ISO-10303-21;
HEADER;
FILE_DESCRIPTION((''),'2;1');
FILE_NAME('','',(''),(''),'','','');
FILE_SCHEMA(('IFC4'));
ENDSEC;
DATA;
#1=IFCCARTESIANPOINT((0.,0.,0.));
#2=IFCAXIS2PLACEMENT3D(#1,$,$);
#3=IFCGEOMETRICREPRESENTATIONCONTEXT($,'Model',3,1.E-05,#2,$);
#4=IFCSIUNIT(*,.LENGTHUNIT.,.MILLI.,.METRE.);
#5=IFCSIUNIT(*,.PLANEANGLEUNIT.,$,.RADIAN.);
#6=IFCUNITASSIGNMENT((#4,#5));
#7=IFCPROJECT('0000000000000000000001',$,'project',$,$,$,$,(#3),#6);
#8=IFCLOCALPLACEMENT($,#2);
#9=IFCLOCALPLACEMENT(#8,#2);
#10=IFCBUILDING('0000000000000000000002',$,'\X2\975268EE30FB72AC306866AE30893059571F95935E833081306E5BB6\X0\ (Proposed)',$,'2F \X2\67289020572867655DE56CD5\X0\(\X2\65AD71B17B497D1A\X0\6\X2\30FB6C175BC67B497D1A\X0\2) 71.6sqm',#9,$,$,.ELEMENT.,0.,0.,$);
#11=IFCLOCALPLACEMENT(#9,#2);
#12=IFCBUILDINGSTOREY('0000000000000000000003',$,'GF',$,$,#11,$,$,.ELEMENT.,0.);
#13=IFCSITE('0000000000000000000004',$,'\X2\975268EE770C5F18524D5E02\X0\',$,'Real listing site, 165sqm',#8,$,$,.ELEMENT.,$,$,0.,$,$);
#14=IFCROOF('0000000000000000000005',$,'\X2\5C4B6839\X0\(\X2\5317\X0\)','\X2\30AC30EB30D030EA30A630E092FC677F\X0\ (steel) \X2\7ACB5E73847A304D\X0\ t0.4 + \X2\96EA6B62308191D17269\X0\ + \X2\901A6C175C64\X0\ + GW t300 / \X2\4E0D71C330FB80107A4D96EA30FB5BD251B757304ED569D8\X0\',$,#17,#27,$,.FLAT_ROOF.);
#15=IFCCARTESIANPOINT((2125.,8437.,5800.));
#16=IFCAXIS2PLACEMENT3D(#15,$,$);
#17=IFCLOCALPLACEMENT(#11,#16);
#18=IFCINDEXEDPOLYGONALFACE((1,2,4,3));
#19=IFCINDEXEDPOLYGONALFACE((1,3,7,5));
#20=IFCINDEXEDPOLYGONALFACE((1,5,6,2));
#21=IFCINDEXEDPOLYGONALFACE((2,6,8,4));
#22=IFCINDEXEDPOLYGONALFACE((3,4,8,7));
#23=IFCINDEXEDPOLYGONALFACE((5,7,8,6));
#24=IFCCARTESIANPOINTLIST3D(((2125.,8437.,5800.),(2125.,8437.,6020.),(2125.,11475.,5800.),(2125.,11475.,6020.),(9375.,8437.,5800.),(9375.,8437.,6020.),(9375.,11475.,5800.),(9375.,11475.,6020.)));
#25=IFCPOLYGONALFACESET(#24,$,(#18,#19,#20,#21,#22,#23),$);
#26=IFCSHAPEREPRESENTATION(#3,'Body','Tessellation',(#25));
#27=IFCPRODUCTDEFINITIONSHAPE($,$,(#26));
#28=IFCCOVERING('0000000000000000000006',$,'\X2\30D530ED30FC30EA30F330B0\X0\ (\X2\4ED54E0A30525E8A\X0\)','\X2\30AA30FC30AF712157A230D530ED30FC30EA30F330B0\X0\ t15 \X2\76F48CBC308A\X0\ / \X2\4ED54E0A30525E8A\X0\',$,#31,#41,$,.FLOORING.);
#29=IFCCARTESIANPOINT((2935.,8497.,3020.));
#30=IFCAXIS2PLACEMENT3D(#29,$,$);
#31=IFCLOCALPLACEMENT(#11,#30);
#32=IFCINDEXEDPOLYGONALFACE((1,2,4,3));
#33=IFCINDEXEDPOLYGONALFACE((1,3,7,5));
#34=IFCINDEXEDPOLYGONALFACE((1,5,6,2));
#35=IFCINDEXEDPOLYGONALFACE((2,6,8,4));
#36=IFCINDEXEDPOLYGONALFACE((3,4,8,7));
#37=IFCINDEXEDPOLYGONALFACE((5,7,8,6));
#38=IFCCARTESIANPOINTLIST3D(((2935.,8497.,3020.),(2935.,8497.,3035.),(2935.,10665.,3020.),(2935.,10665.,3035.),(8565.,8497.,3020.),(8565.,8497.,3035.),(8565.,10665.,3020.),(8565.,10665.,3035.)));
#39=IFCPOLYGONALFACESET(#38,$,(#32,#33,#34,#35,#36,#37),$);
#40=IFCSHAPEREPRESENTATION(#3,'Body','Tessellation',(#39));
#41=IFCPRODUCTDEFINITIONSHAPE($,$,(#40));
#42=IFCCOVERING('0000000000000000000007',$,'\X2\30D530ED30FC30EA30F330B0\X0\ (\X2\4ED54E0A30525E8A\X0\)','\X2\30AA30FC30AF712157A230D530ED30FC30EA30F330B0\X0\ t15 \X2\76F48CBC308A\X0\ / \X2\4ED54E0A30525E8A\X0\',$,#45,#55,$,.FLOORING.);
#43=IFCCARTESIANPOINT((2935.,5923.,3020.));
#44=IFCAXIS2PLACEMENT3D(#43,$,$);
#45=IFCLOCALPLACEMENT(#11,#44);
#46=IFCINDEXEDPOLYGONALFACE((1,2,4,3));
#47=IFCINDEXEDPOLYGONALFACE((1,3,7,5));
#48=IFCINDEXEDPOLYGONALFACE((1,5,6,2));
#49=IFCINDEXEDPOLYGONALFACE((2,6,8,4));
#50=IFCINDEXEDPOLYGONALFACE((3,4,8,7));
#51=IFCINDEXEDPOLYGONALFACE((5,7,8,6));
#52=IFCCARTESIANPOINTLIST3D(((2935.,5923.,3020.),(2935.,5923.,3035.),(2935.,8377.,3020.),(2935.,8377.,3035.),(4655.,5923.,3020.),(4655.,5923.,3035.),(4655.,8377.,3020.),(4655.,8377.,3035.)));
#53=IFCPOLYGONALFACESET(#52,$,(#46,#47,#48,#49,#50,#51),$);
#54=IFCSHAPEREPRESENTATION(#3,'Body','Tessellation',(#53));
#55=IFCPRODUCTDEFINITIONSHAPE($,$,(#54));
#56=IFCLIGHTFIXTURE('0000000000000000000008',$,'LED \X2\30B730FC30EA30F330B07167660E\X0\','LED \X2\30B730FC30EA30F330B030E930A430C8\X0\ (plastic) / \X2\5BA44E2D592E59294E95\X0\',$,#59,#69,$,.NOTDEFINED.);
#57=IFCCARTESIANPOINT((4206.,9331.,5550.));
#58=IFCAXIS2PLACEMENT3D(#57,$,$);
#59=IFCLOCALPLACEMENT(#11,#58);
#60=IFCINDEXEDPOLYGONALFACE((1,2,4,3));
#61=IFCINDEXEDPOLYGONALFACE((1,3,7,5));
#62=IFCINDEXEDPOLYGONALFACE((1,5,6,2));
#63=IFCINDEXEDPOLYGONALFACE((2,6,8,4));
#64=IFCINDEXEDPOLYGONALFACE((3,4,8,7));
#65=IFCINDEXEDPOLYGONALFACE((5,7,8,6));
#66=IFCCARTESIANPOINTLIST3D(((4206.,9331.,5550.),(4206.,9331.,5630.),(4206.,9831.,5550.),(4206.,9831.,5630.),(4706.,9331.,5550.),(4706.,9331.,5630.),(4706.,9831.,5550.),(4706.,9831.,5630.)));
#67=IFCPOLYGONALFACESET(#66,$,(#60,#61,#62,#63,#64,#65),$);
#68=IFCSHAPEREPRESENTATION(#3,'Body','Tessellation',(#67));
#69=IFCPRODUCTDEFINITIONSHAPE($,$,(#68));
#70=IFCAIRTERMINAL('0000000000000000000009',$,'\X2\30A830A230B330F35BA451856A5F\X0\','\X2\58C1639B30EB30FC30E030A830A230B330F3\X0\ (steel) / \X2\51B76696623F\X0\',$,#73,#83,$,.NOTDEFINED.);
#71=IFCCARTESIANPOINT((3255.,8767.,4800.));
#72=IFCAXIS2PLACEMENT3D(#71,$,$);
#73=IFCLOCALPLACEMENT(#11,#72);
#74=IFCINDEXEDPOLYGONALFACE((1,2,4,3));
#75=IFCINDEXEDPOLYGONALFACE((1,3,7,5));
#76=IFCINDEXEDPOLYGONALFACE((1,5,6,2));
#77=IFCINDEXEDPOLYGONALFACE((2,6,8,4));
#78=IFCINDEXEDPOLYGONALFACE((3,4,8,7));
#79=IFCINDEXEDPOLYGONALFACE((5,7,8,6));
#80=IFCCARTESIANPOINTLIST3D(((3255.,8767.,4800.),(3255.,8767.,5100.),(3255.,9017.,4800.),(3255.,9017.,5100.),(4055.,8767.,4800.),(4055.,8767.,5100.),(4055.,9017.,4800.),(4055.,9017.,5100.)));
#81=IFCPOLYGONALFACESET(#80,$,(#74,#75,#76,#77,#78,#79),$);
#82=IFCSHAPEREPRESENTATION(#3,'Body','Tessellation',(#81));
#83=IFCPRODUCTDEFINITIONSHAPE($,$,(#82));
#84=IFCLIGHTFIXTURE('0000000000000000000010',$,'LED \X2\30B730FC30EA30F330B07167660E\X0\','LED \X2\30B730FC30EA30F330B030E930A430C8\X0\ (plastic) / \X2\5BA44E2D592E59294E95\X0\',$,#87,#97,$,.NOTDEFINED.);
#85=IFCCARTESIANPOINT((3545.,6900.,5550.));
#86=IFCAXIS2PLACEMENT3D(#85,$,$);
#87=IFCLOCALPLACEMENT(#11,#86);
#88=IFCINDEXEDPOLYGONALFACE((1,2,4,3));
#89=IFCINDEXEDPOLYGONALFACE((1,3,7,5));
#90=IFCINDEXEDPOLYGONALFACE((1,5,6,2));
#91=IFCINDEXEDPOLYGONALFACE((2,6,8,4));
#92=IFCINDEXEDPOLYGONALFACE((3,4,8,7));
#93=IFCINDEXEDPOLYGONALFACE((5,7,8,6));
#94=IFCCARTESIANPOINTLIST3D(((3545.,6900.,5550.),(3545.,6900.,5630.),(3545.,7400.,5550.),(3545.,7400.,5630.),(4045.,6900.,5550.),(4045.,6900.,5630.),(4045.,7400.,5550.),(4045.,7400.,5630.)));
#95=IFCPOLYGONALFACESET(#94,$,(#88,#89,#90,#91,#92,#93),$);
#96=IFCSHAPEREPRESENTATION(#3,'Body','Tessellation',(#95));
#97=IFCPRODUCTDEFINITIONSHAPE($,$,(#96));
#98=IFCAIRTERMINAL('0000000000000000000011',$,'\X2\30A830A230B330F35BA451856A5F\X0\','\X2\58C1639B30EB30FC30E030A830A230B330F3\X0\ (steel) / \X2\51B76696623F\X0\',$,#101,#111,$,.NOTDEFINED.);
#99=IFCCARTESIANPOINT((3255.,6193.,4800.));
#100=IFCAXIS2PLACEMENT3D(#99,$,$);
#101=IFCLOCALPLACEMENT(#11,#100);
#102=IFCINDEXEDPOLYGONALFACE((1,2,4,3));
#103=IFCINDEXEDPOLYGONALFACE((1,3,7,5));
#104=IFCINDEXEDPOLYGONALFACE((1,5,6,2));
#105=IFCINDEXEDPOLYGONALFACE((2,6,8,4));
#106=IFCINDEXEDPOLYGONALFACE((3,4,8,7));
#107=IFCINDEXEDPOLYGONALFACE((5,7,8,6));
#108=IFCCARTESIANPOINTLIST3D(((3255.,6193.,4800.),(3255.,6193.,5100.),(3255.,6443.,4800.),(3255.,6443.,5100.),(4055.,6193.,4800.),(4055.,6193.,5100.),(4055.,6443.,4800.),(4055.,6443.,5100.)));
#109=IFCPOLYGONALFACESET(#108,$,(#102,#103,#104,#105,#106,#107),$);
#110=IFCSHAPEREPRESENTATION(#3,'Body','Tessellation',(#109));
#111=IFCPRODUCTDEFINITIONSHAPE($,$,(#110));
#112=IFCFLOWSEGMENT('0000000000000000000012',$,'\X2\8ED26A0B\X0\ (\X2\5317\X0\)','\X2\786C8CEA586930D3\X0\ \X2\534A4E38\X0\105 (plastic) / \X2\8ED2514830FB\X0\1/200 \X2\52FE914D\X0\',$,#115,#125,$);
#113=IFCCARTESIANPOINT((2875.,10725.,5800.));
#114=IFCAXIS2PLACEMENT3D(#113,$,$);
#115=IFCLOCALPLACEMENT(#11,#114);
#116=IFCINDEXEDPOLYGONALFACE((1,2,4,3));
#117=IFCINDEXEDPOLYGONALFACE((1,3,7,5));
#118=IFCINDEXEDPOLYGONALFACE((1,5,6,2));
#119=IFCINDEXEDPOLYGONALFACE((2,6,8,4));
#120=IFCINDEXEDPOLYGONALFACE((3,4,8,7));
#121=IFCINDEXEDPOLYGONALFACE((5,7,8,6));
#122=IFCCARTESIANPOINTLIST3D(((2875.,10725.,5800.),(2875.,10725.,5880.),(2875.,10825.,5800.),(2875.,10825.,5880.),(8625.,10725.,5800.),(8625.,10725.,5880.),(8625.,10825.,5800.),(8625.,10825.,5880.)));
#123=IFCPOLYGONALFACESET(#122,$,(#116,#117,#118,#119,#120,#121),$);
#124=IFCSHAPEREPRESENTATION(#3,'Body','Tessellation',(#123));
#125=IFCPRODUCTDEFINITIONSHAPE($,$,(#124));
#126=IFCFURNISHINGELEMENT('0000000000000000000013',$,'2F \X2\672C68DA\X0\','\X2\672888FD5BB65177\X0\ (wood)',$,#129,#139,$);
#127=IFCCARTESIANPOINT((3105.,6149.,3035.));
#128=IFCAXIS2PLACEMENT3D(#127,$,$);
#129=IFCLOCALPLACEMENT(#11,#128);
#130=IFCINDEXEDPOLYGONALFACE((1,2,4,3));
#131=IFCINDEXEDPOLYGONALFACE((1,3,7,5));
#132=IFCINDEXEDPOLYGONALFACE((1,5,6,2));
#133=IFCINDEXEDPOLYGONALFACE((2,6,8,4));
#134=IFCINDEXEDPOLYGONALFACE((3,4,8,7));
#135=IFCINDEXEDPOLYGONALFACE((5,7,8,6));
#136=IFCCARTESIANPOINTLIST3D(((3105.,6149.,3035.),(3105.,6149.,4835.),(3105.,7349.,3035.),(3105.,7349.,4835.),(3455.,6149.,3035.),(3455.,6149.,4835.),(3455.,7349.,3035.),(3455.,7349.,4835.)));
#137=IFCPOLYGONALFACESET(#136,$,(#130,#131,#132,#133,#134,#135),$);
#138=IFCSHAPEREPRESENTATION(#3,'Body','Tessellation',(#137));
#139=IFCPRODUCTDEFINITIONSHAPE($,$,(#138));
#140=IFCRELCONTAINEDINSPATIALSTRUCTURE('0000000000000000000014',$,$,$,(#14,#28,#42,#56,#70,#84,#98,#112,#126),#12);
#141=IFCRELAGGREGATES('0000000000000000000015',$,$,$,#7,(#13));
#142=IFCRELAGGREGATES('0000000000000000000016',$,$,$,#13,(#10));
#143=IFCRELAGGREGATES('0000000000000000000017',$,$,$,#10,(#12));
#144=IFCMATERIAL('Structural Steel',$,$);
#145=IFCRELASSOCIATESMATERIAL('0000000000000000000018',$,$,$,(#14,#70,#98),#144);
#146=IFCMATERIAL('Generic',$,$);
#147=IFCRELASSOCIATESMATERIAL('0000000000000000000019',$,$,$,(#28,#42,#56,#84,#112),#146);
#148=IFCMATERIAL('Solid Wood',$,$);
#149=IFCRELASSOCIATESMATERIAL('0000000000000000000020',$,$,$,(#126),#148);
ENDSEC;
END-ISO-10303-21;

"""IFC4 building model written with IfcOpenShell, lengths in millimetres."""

from ifc_helpers import new_model, si_unit, frame, frame_2d, origin, place, context, project, spatial, rectangle, extrude, material, element, save


model = new_model("IFC4")

# Units and contexts
model_context = context("Model", 3, precision=1e-05, world=origin())
ifc_project = project(units=[si_unit("LENGTHUNIT", "METRE", prefix="MILLI"), si_unit("PLANEANGLEUNIT", "RADIAN")], contexts=[model_context])

# Site, building, storey
site_placement = place(None, origin())
site = spatial("IfcSite", under=ifc_project, at=site_placement, Name="青森県弘前市", ObjectType="Real listing site, 165sqm", CompositionType="ELEMENT", RefElevation=0.0)
building_placement = place(site_placement, origin())
building = spatial("IfcBuilding", under=site, at=building_placement, Name="青森・犬と暮らす土間広めの家 (Proposed)", ObjectType="2F 木造在来工法(断熱等級6・気密等級2) 71.6sqm", CompositionType="ELEMENT", ElevationOfRefHeight=0.0, ElevationOfTerrain=0.0)
storey_placement = place(building_placement, origin())
storey = spatial("IfcBuildingStorey", under=building, at=storey_placement, Name="GF", CompositionType="ELEMENT", Elevation=0.0)

# Shared definitions
ifc_material_1 = material(Name="Solid Wood")

# Roof
ifc_material_2 = material(Name="Structural Steel")
for number, where, name in (
    (1, (2125.0, 8437.0, 5800.0), "屋根(北)"),
):
    element("IfcRoof", number, at=place(storey_placement, frame(where)), inside=storey, material=ifc_material_2, Name=name, Description="ガルバリウム鋼板 (steel) 立平葺き t0.4 + 雪止め金物 + 通気層 + GW t300 / 不燃・耐積雪・寒冷地仕様", PredefinedType="FLAT_ROOF", context=model_context, shape_type="SweptSolid", body=[
        extrude(rectangle(XDim=7250.0, YDim=3038.0, at=frame_2d((3625.0, 1519.0))), frame((2125.0, 8437.0, 5800.0)), (0.0, 0.0, 1.0), 220.0),
    ])

# Coverings
ifc_material_3 = material(Name="Generic")
covering_1_placement = place(storey_placement, frame((2935.0, 8497.0, 3020.0)))
element("IfcCovering", 2, at=covering_1_placement, inside=storey, material=ifc_material_3, Name="フローリング (仕上げ床)", Description="オーク無垢フローリング t15 直貼り / 仕上げ床", PredefinedType="FLOORING", context=model_context, shape_type="SweptSolid", body=[
    extrude(rectangle(XDim=5630.0, YDim=2168.0, at=frame_2d((2815.0, 1084.0))), frame((2935.0, 8497.0, 3020.0)), (0.0, 0.0, 1.0), 15.0),
])
covering_2_placement = place(storey_placement, frame((2935.0, 5923.0, 3020.0)))
element("IfcCovering", 3, at=covering_2_placement, inside=storey, material=ifc_material_3, Name="フローリング (仕上げ床)", Description="オーク無垢フローリング t15 直貼り / 仕上げ床", PredefinedType="FLOORING", context=model_context, shape_type="SweptSolid", body=[
    extrude(rectangle(XDim=1720.0, YDim=2454.0, at=frame_2d((860.0, 1227.0))), frame((2935.0, 5923.0, 3020.0)), (0.0, 0.0, 1.0), 15.0),
])

# Light fixture
light_fixture_1_placement = place(storey_placement, frame((4206.0, 9331.0, 5550.0)))
element("IfcLightFixture", 4, at=light_fixture_1_placement, inside=storey, material=ifc_material_3, Name="LED シーリング照明", Description="LED シーリングライト (plastic) / 室中央天井", PredefinedType="NOTDEFINED", context=model_context, shape_type="SweptSolid", body=[
    extrude(rectangle(XDim=500.0, YDim=500.0, at=frame_2d((250.0, 250.0))), frame((4206.0, 9331.0, 5550.0)), (0.0, 0.0, 1.0), 80.0),
])

# Air terminal
air_terminal_1_placement = place(storey_placement, frame((3255.0, 8767.0, 4800.0)))
element("IfcAirTerminal", 5, at=air_terminal_1_placement, inside=storey, material=ifc_material_2, Name="エアコン室内機", Description="壁掛ルームエアコン (steel) / 冷暖房", PredefinedType="NOTDEFINED", context=model_context, shape_type="SweptSolid", body=[
    extrude(rectangle(XDim=800.0, YDim=250.0, at=frame_2d((400.0, 125.0))), frame((3255.0, 8767.0, 4800.0)), (0.0, 0.0, 1.0), 300.0),
])

# Light fixture
light_fixture_2_placement = place(storey_placement, frame((3545.0, 6900.0, 5550.0)))
element("IfcLightFixture", 6, at=light_fixture_2_placement, inside=storey, material=ifc_material_3, Name="LED シーリング照明", Description="LED シーリングライト (plastic) / 室中央天井", PredefinedType="NOTDEFINED", context=model_context, shape_type="SweptSolid", body=[
    extrude(rectangle(XDim=500.0, YDim=500.0, at=frame_2d((250.0, 250.0))), frame((3545.0, 6900.0, 5550.0)), (0.0, 0.0, 1.0), 80.0),
])

# Air terminal
air_terminal_2_placement = place(storey_placement, frame((3255.0, 6193.0, 4800.0)))
element("IfcAirTerminal", 7, at=air_terminal_2_placement, inside=storey, material=ifc_material_2, Name="エアコン室内機", Description="壁掛ルームエアコン (steel) / 冷暖房", PredefinedType="NOTDEFINED", context=model_context, shape_type="SweptSolid", body=[
    extrude(rectangle(XDim=800.0, YDim=250.0, at=frame_2d((400.0, 125.0))), frame((3255.0, 6193.0, 4800.0)), (0.0, 0.0, 1.0), 300.0),
])

# Flow segment
flow_segment_placement = place(storey_placement, frame((2875.0, 10725.0, 5800.0)))
element("IfcFlowSegment", 8, at=flow_segment_placement, inside=storey, material=ifc_material_3, Name="軒樋 (北)", Description="硬質塩ビ 半丸105 (plastic) / 軒先・1/200 勾配", context=model_context, shape_type="SweptSolid", body=[
    extrude(rectangle(XDim=5750.0, YDim=100.0, at=frame_2d((2875.0, 50.0))), frame((2875.0, 10725.0, 5800.0)), (0.0, 0.0, 1.0), 80.0),
])

# Furnishing element
furnishing_placement = place(storey_placement, frame((3105.0, 6149.0, 3035.0)))
element("IfcFurnishingElement", 9, at=furnishing_placement, inside=storey, material=ifc_material_1, Name="2F 本棚", Description="木製家具 (wood)", context=model_context, shape_type="SweptSolid", body=[
    extrude(rectangle(XDim=350.0, YDim=1200.0, at=frame_2d((175.0, 600.0))), frame((3105.0, 6149.0, 3035.0)), (0.0, 0.0, 1.0), 1800.0),
])

save(model, "model.ifc")
